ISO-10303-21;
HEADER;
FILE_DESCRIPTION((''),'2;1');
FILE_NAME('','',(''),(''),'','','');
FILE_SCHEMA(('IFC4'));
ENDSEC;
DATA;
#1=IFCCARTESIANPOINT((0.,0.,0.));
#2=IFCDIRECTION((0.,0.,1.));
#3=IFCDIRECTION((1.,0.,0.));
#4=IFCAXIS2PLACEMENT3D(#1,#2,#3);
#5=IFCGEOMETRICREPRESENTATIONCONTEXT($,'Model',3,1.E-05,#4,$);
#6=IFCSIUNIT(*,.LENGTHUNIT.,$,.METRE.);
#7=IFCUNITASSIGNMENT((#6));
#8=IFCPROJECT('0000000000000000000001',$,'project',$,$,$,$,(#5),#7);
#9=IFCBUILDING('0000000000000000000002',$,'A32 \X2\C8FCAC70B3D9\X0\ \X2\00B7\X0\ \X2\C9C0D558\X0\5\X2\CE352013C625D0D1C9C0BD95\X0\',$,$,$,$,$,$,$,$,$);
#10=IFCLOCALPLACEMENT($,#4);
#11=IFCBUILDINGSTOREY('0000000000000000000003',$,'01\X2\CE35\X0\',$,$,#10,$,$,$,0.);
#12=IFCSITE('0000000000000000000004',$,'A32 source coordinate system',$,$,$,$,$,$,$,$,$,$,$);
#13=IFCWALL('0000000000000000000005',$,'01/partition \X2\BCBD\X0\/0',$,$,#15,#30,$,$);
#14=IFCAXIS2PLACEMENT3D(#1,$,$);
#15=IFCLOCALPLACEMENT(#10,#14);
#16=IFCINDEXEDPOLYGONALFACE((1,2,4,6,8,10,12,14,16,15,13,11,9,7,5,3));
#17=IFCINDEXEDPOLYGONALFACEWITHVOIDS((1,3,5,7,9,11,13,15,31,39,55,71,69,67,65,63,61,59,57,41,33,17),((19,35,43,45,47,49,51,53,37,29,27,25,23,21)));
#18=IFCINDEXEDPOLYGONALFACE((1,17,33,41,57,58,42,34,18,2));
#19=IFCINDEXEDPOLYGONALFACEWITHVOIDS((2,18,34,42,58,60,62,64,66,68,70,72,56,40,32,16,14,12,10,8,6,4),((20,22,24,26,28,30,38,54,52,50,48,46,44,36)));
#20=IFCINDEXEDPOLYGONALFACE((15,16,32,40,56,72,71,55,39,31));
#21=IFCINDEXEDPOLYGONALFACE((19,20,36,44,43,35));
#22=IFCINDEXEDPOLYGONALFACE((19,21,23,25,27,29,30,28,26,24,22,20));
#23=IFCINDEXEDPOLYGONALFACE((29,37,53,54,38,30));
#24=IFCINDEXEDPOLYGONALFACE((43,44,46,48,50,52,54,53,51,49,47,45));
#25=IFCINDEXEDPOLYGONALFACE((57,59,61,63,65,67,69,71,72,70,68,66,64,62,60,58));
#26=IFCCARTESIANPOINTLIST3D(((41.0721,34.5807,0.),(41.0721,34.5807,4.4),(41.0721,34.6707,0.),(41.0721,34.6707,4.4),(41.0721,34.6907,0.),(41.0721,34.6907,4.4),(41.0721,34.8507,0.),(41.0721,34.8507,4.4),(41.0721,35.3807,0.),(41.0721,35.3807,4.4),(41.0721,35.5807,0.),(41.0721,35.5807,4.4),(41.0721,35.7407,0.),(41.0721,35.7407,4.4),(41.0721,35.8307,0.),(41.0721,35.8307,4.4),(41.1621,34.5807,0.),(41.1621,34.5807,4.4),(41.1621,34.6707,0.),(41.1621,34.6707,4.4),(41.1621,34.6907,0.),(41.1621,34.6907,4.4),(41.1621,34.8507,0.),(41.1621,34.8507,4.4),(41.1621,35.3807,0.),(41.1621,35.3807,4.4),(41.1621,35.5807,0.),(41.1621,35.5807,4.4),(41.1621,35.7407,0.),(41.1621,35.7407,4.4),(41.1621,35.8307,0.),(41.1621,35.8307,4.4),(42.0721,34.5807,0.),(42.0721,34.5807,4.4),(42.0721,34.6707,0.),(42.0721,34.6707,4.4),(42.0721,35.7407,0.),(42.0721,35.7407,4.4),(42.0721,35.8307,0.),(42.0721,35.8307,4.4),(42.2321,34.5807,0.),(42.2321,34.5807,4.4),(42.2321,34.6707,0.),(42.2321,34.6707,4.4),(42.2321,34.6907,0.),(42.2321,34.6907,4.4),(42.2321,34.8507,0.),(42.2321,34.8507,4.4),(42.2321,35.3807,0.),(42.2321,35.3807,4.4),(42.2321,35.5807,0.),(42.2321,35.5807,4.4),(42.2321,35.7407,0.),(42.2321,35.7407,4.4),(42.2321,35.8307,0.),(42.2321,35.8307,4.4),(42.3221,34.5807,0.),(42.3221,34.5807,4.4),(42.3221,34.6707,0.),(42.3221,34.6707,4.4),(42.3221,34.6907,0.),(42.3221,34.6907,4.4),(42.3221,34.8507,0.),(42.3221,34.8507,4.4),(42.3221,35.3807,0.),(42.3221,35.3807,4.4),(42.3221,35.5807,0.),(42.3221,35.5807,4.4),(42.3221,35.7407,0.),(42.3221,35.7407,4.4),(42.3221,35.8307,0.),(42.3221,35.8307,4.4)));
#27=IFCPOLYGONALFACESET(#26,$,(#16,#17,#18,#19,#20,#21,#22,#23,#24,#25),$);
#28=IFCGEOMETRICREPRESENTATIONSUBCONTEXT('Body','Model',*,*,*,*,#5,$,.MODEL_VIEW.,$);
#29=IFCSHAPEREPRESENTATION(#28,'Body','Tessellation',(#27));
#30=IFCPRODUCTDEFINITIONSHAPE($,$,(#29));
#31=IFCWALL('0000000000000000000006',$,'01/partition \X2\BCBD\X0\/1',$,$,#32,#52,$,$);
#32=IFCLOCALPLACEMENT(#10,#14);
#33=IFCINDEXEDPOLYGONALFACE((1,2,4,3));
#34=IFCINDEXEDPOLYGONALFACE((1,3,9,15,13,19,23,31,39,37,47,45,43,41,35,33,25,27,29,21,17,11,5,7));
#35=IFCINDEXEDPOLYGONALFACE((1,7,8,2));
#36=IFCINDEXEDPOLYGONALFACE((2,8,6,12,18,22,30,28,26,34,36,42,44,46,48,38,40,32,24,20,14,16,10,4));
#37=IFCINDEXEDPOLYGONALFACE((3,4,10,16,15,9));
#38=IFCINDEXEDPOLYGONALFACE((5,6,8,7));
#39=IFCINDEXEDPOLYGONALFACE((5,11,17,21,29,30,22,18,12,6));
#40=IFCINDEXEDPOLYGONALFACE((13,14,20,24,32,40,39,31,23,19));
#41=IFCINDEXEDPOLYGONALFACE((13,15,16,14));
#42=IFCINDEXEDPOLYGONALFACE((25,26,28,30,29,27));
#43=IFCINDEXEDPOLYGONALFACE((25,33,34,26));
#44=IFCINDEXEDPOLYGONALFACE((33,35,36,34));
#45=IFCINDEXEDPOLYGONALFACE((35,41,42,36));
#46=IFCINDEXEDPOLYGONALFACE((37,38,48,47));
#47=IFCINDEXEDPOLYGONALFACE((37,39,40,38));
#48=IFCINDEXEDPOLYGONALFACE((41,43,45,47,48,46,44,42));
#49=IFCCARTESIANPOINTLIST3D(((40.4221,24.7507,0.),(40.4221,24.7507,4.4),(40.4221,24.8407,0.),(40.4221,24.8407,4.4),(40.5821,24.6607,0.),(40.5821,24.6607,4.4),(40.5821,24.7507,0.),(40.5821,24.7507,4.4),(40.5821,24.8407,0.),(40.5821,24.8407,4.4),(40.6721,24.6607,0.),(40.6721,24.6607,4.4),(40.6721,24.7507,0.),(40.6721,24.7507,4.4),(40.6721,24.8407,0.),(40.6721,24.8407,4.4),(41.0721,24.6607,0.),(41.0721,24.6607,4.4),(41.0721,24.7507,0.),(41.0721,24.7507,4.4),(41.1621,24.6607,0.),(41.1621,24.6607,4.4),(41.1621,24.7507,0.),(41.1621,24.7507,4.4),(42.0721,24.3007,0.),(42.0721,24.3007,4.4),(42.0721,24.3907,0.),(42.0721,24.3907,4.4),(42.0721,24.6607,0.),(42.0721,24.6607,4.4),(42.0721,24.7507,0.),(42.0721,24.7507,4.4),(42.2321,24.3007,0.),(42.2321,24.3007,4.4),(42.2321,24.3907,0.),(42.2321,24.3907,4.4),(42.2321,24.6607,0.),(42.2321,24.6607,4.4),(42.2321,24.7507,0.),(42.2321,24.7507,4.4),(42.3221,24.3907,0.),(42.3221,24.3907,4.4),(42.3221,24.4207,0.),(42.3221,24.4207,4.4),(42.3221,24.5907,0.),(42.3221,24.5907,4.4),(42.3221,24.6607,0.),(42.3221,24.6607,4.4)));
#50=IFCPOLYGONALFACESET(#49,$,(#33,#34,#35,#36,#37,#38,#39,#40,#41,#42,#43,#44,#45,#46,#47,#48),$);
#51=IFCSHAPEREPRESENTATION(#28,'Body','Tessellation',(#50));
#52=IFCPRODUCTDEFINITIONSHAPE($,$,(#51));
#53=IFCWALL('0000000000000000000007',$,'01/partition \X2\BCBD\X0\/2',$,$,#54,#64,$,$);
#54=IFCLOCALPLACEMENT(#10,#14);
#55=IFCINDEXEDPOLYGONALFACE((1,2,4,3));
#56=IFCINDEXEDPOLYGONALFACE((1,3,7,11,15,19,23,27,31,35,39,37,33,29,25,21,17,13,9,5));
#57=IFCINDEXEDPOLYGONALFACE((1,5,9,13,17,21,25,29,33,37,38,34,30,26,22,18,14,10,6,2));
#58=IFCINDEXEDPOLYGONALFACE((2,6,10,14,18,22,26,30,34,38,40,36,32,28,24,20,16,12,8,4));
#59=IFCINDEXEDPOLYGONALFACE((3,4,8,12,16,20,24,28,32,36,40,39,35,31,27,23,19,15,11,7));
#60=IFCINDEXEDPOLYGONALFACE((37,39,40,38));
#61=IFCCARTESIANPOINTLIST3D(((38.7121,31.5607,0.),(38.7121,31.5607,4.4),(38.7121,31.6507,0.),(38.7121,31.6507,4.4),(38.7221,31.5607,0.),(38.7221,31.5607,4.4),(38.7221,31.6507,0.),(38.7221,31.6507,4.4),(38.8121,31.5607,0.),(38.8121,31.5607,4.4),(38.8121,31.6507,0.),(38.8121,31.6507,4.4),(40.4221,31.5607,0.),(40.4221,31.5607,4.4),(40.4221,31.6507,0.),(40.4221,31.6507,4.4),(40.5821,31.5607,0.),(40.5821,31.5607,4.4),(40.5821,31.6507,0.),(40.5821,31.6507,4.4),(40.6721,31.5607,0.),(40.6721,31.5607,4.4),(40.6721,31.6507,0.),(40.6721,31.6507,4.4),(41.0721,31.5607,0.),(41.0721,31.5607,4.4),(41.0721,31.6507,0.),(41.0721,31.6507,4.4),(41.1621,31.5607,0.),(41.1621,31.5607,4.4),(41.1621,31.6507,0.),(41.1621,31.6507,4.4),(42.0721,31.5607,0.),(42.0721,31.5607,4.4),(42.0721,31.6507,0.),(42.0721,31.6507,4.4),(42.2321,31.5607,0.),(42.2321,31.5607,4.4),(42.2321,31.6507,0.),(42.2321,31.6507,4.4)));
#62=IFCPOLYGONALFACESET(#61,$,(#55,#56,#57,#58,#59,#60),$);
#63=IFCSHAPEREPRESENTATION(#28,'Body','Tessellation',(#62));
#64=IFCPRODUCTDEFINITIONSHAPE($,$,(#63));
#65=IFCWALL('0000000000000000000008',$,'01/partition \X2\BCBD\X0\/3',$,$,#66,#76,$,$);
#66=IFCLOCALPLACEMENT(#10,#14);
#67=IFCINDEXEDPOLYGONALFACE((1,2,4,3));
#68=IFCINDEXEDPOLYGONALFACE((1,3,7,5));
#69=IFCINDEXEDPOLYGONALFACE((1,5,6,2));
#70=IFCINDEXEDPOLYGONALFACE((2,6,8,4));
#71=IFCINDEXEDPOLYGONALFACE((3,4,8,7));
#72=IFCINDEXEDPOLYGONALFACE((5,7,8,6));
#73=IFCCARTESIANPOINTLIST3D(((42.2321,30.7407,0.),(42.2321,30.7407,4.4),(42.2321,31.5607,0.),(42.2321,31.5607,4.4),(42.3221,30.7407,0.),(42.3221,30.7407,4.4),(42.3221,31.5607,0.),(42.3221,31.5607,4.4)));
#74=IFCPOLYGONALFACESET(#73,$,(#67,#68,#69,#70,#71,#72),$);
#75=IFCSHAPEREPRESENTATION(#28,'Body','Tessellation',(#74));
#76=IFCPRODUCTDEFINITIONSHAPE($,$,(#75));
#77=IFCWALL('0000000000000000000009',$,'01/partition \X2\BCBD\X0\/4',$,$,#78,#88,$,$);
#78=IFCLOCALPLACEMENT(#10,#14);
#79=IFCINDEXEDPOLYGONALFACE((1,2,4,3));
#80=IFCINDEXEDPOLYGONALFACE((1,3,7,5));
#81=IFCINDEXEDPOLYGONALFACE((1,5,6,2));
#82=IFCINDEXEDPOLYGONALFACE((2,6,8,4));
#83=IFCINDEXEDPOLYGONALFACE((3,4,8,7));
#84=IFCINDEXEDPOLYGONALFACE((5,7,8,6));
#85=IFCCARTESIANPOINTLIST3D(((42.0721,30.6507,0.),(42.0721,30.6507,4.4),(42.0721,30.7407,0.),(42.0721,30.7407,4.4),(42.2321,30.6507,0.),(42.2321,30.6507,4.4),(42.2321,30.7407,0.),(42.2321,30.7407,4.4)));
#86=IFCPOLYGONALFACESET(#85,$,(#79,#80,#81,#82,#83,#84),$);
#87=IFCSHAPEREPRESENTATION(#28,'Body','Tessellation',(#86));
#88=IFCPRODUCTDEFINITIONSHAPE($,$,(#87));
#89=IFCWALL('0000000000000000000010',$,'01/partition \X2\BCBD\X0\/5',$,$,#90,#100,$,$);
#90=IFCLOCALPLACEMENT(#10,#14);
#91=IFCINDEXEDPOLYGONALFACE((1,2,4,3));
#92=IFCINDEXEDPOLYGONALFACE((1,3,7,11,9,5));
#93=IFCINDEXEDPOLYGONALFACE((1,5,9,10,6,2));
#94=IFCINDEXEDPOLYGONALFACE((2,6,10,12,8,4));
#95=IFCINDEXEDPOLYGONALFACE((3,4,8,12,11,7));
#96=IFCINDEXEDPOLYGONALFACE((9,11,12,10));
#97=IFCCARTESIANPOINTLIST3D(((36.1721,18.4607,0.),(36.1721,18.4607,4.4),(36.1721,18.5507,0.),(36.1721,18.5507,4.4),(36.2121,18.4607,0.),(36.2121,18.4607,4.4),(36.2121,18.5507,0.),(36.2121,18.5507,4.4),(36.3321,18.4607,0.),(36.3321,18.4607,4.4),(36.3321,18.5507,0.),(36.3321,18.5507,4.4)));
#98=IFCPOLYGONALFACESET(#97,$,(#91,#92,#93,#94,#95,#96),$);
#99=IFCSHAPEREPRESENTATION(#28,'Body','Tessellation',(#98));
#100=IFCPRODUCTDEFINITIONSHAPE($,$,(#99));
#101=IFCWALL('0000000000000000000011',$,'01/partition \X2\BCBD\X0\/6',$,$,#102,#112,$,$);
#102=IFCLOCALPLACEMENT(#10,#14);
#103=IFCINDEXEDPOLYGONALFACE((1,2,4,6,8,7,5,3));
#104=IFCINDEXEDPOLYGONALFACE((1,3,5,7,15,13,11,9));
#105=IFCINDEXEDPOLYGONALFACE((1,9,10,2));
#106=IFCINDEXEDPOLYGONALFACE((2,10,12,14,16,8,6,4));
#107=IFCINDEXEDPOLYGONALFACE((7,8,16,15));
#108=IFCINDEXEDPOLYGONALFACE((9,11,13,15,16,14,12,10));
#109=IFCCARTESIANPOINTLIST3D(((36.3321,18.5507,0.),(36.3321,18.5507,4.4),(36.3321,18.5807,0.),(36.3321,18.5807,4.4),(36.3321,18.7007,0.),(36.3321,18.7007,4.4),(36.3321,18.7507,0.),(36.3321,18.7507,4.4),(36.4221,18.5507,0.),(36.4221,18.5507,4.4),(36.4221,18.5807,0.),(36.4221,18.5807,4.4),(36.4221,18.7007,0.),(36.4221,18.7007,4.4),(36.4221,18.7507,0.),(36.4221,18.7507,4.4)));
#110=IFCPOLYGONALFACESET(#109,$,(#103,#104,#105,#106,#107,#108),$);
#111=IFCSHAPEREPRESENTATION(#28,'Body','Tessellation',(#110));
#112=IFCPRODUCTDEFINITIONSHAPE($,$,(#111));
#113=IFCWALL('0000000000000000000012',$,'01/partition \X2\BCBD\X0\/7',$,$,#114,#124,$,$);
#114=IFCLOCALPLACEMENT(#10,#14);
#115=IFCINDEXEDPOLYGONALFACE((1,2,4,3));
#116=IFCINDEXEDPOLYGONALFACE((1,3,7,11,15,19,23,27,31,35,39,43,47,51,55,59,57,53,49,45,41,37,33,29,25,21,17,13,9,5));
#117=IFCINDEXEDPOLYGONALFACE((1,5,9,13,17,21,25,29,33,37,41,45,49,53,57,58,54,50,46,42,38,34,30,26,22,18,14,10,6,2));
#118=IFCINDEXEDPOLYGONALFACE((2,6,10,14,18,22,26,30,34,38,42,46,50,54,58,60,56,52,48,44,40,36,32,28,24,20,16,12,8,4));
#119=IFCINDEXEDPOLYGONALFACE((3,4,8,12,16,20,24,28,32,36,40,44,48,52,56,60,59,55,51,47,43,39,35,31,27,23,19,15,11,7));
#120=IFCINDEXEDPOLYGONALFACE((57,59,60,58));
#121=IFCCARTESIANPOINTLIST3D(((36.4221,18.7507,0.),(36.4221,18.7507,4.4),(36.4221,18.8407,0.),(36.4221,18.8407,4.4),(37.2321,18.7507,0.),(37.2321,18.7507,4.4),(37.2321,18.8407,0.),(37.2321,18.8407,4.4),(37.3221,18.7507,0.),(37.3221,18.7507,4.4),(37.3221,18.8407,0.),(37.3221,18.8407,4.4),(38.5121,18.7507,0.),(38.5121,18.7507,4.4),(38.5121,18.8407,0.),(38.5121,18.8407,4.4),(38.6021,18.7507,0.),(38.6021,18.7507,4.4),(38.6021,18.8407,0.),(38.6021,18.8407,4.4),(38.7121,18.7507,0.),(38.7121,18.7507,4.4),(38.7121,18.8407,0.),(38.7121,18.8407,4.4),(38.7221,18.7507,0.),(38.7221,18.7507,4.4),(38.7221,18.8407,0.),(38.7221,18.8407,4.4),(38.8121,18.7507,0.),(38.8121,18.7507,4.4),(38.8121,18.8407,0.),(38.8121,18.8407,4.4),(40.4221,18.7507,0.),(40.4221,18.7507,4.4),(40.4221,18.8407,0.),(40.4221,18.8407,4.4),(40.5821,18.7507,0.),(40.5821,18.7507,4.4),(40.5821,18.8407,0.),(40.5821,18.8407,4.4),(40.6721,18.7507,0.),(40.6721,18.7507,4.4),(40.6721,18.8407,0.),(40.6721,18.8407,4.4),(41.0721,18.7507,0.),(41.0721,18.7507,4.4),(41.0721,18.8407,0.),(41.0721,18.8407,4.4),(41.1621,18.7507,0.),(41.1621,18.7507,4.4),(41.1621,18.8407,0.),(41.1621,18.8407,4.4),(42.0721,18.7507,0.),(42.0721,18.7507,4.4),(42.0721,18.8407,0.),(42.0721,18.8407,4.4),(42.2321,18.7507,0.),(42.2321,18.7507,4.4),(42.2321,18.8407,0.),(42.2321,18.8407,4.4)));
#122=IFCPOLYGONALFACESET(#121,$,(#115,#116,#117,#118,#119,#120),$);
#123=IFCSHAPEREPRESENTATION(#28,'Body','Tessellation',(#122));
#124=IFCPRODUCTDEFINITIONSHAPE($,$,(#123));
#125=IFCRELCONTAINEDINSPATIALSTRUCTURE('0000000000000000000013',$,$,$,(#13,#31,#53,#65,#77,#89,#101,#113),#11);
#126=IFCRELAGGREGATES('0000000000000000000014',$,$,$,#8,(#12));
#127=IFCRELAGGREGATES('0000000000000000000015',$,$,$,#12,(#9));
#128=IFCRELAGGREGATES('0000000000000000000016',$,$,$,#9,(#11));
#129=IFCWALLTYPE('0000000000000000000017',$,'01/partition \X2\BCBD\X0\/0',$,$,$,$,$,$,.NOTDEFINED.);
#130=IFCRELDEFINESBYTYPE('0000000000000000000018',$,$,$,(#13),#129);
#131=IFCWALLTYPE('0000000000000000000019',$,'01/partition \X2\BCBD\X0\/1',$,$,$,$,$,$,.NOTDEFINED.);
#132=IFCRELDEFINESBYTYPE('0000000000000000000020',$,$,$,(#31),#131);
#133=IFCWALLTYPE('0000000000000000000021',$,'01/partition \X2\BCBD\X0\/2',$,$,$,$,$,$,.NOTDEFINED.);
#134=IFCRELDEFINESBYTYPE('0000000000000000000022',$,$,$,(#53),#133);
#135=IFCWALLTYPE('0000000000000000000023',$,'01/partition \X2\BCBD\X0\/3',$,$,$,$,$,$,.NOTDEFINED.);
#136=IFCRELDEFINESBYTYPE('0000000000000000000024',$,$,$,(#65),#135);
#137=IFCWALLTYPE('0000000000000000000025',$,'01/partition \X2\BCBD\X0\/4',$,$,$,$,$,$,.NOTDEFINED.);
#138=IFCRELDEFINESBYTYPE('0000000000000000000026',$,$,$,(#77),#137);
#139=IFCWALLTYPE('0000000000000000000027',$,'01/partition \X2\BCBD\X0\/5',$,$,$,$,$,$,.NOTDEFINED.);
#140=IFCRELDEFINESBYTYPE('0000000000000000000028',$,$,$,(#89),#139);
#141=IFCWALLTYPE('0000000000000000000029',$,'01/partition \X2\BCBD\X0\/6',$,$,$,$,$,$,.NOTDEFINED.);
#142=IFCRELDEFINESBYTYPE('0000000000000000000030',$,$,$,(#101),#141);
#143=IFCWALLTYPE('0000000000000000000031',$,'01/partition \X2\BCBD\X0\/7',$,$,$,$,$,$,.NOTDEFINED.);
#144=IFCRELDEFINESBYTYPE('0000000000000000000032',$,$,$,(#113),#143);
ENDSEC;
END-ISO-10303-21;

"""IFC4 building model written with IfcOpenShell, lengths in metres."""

from ifc_helpers import new_model, si_unit, origin, origin_with_axes, place, context, subcontext, project, spatial, polyline, outline, extrude, source, transform, mapped, type_object, type_shapes, element, save


model = new_model("IFC4")

# Units and contexts
model_context = context("Model", 3, precision=1e-05, world=origin_with_axes())
body_context = subcontext(model_context, "Body", "Model", "MODEL_VIEW")
ifc_project = project(units=[si_unit("LENGTHUNIT", "METRE")], contexts=[model_context])

# Site, building, storey
site = spatial("IfcSite", under=ifc_project, Name="A32 source coordinate system")
building = spatial("IfcBuilding", under=site, Name="A32 주거동 · 지하5층–옥탑지붕")
storey_placement = place(None, origin_with_axes())
storey = spatial("IfcBuildingStorey", under=building, at=storey_placement, Name="01층", Elevation=0.0)

# Walls
wall_type_1 = type_object("IfcWallType", Name="01/partition 벽/0", PredefinedType="NOTDEFINED")
shared_shape_1 = source(origin(), body_context, "Body", "SweptSolid", [
    extrude(outline(polyline([(41.0721, 34.8507), (41.0721, 35.3807), (41.0721, 35.5807), (41.0721, 35.7407), (41.0721, 35.8307), (41.1621, 35.8307), (42.0721, 35.8307), (42.2321, 35.8307), (42.3221, 35.8307), (42.3221, 35.7407), (42.3221, 35.5807), (42.3221, 35.3807), (42.3221, 34.8507), (42.3221, 34.6907), (42.3221, 34.6707), (42.3221, 34.5807), (42.2321, 34.5807), (42.0721, 34.5807), (41.1621, 34.5807), (41.0721, 34.5807), (41.0721, 34.6707), (41.0721, 34.6907), (41.0721, 34.8507)]), holes=[polyline([(42.2321, 35.5807), (42.2321, 35.7407), (42.0721, 35.7407), (41.1621, 35.7407), (41.1621, 35.5807), (41.1621, 35.3807), (41.1621, 34.8507), (41.1621, 34.6907), (41.1621, 34.6707), (42.0721, 34.6707), (42.2321, 34.6707), (42.2321, 34.6907), (42.2321, 34.8507), (42.2321, 35.3807), (42.2321, 35.5807)])]), origin(), (0.0, 0.0, 1.0), 4.4),
])
type_shapes(wall_type_1, [shared_shape_1])
wall_1_placement = place(storey_placement, origin_with_axes())
element("IfcWall", 1, at=wall_1_placement, inside=storey, type_object=wall_type_1, Name="01/partition 벽/0", context=body_context, shape_type="MappedRepresentation", body=[
    mapped(shared_shape_1, transform((0.0, 0.0, 0.0), scale=1.0)),
])
wall_type_2 = type_object("IfcWallType", Name="01/partition 벽/1", PredefinedType="NOTDEFINED")
shared_shape_2 = source(origin(), body_context, "Body", "SweptSolid", [
    extrude(outline(polyline([(40.6721, 24.6607), (40.5821, 24.6607), (40.5821, 24.7507), (40.4221, 24.7507), (40.4221, 24.8407), (40.5821, 24.8407), (40.6721, 24.8407), (40.6721, 24.7507), (41.0721, 24.7507), (41.1621, 24.7507), (42.0721, 24.7507), (42.2321, 24.7507), (42.2321, 24.6607), (42.3221, 24.6607), (42.3221, 24.5907), (42.3221, 24.4207), (42.3221, 24.3907), (42.2321, 24.3907), (42.2321, 24.3007), (42.0721, 24.3007), (42.0721, 24.3907), (42.0721, 24.6607), (41.1621, 24.6607), (41.0721, 24.6607), (40.6721, 24.6607)])), origin(), (0.0, 0.0, 1.0), 4.4),
])
type_shapes(wall_type_2, [shared_shape_2])
wall_2_placement = place(storey_placement, origin_with_axes())
element("IfcWall", 2, at=wall_2_placement, inside=storey, type_object=wall_type_2, Name="01/partition 벽/1", context=body_context, shape_type="MappedRepresentation", body=[
    mapped(shared_shape_2, transform((0.0, 0.0, 0.0), scale=1.0)),
])
wall_type_3 = type_object("IfcWallType", Name="01/partition 벽/2", PredefinedType="NOTDEFINED")
shared_shape_3 = source(origin(), body_context, "Body", "SweptSolid", [
    extrude(outline(polyline([(38.8121, 31.6507), (40.4221, 31.6507), (40.5821, 31.6507), (40.6721, 31.6507), (41.0721, 31.6507), (41.1621, 31.6507), (42.0721, 31.6507), (42.2321, 31.6507), (42.2321, 31.5607), (42.0721, 31.5607), (41.1621, 31.5607), (41.0721, 31.5607), (40.6721, 31.5607), (40.5821, 31.5607), (40.4221, 31.5607), (38.8121, 31.5607), (38.7221, 31.5607), (38.7121, 31.5607), (38.7121, 31.6507), (38.7221, 31.6507), (38.8121, 31.6507)])), origin(), (0.0, 0.0, 1.0), 4.4),
])
type_shapes(wall_type_3, [shared_shape_3])
wall_3_placement = place(storey_placement, origin_with_axes())
element("IfcWall", 3, at=wall_3_placement, inside=storey, type_object=wall_type_3, Name="01/partition 벽/2", context=body_context, shape_type="MappedRepresentation", body=[
    mapped(shared_shape_3, transform((0.0, 0.0, 0.0), scale=1.0)),
])
wall_type_4 = type_object("IfcWallType", Name="01/partition 벽/3", PredefinedType="NOTDEFINED")
shared_shape_4 = source(origin(), body_context, "Body", "SweptSolid", [
    extrude(outline(polyline([(42.3221, 31.5607), (42.3221, 30.7407), (42.2321, 30.7407), (42.2321, 31.5607), (42.3221, 31.5607)])), origin(), (0.0, 0.0, 1.0), 4.4),
])
type_shapes(wall_type_4, [shared_shape_4])
wall_4_placement = place(storey_placement, origin_with_axes())
element("IfcWall", 4, at=wall_4_placement, inside=storey, type_object=wall_type_4, Name="01/partition 벽/3", context=body_context, shape_type="MappedRepresentation", body=[
    mapped(shared_shape_4, transform((0.0, 0.0, 0.0), scale=1.0)),
])
wall_type_5 = type_object("IfcWallType", Name="01/partition 벽/4", PredefinedType="NOTDEFINED")
shared_shape_5 = source(origin(), body_context, "Body", "SweptSolid", [
    extrude(outline(polyline([(42.2321, 30.6507), (42.0721, 30.6507), (42.0721, 30.7407), (42.2321, 30.7407), (42.2321, 30.6507)])), origin(), (0.0, 0.0, 1.0), 4.4),
])
type_shapes(wall_type_5, [shared_shape_5])
wall_5_placement = place(storey_placement, origin_with_axes())
element("IfcWall", 5, at=wall_5_placement, inside=storey, type_object=wall_type_5, Name="01/partition 벽/4", context=body_context, shape_type="MappedRepresentation", body=[
    mapped(shared_shape_5, transform((0.0, 0.0, 0.0), scale=1.0)),
])
wall_type_6 = type_object("IfcWallType", Name="01/partition 벽/5", PredefinedType="NOTDEFINED")
shared_shape_6 = source(origin(), body_context, "Body", "SweptSolid", [
    extrude(outline(polyline([(36.1721, 18.4607), (36.1721, 18.5507), (36.2121, 18.5507), (36.3321, 18.5507), (36.3321, 18.4607), (36.2121, 18.4607), (36.1721, 18.4607)])), origin(), (0.0, 0.0, 1.0), 4.4),
])
type_shapes(wall_type_6, [shared_shape_6])
wall_6_placement = place(storey_placement, origin_with_axes())
element("IfcWall", 6, at=wall_6_placement, inside=storey, type_object=wall_type_6, Name="01/partition 벽/5", context=body_context, shape_type="MappedRepresentation", body=[
    mapped(shared_shape_6, transform((0.0, 0.0, 0.0), scale=1.0)),
])
wall_type_7 = type_object("IfcWallType", Name="01/partition 벽/6", PredefinedType="NOTDEFINED")
shared_shape_7 = source(origin(), body_context, "Body", "SweptSolid", [
    extrude(outline(polyline([(36.3321, 18.5807), (36.3321, 18.7007), (36.3321, 18.7507), (36.4221, 18.7507), (36.4221, 18.7007), (36.4221, 18.5807), (36.4221, 18.5507), (36.3321, 18.5507), (36.3321, 18.5807)])), origin(), (0.0, 0.0, 1.0), 4.4),
])
type_shapes(wall_type_7, [shared_shape_7])
wall_7_placement = place(storey_placement, origin_with_axes())
element("IfcWall", 7, at=wall_7_placement, inside=storey, type_object=wall_type_7, Name="01/partition 벽/6", context=body_context, shape_type="MappedRepresentation", body=[
    mapped(shared_shape_7, transform((0.0, 0.0, 0.0), scale=1.0)),
])
wall_type_8 = type_object("IfcWallType", Name="01/partition 벽/7", PredefinedType="NOTDEFINED")
shared_shape_8 = source(origin(), body_context, "Body", "SweptSolid", [
    extrude(outline(polyline([(36.4221, 18.8407), (37.2321, 18.8407), (37.3221, 18.8407), (38.5121, 18.8407), (38.6021, 18.8407), (38.7121, 18.8407), (38.7221, 18.8407), (38.8121, 18.8407), (40.4221, 18.8407), (40.5821, 18.8407), (40.6721, 18.8407), (41.0721, 18.8407), (41.1621, 18.8407), (42.0721, 18.8407), (42.2321, 18.8407), (42.2321, 18.7507), (42.0721, 18.7507), (41.1621, 18.7507), (41.0721, 18.7507), (40.6721, 18.7507), (40.5821, 18.7507), (40.4221, 18.7507), (38.8121, 18.7507), (38.7221, 18.7507), (38.7121, 18.7507), (38.6021, 18.7507), (38.5121, 18.7507), (37.3221, 18.7507), (37.2321, 18.7507), (36.4221, 18.7507), (36.4221, 18.8407)])), origin(), (0.0, 0.0, 1.0), 4.4),
])
type_shapes(wall_type_8, [shared_shape_8])
wall_8_placement = place(storey_placement, origin_with_axes())
element("IfcWall", 8, at=wall_8_placement, inside=storey, type_object=wall_type_8, Name="01/partition 벽/7", context=body_context, shape_type="MappedRepresentation", body=[
    mapped(shared_shape_8, transform((0.0, 0.0, 0.0), scale=1.0)),
])

save(model, "model.ifc")
